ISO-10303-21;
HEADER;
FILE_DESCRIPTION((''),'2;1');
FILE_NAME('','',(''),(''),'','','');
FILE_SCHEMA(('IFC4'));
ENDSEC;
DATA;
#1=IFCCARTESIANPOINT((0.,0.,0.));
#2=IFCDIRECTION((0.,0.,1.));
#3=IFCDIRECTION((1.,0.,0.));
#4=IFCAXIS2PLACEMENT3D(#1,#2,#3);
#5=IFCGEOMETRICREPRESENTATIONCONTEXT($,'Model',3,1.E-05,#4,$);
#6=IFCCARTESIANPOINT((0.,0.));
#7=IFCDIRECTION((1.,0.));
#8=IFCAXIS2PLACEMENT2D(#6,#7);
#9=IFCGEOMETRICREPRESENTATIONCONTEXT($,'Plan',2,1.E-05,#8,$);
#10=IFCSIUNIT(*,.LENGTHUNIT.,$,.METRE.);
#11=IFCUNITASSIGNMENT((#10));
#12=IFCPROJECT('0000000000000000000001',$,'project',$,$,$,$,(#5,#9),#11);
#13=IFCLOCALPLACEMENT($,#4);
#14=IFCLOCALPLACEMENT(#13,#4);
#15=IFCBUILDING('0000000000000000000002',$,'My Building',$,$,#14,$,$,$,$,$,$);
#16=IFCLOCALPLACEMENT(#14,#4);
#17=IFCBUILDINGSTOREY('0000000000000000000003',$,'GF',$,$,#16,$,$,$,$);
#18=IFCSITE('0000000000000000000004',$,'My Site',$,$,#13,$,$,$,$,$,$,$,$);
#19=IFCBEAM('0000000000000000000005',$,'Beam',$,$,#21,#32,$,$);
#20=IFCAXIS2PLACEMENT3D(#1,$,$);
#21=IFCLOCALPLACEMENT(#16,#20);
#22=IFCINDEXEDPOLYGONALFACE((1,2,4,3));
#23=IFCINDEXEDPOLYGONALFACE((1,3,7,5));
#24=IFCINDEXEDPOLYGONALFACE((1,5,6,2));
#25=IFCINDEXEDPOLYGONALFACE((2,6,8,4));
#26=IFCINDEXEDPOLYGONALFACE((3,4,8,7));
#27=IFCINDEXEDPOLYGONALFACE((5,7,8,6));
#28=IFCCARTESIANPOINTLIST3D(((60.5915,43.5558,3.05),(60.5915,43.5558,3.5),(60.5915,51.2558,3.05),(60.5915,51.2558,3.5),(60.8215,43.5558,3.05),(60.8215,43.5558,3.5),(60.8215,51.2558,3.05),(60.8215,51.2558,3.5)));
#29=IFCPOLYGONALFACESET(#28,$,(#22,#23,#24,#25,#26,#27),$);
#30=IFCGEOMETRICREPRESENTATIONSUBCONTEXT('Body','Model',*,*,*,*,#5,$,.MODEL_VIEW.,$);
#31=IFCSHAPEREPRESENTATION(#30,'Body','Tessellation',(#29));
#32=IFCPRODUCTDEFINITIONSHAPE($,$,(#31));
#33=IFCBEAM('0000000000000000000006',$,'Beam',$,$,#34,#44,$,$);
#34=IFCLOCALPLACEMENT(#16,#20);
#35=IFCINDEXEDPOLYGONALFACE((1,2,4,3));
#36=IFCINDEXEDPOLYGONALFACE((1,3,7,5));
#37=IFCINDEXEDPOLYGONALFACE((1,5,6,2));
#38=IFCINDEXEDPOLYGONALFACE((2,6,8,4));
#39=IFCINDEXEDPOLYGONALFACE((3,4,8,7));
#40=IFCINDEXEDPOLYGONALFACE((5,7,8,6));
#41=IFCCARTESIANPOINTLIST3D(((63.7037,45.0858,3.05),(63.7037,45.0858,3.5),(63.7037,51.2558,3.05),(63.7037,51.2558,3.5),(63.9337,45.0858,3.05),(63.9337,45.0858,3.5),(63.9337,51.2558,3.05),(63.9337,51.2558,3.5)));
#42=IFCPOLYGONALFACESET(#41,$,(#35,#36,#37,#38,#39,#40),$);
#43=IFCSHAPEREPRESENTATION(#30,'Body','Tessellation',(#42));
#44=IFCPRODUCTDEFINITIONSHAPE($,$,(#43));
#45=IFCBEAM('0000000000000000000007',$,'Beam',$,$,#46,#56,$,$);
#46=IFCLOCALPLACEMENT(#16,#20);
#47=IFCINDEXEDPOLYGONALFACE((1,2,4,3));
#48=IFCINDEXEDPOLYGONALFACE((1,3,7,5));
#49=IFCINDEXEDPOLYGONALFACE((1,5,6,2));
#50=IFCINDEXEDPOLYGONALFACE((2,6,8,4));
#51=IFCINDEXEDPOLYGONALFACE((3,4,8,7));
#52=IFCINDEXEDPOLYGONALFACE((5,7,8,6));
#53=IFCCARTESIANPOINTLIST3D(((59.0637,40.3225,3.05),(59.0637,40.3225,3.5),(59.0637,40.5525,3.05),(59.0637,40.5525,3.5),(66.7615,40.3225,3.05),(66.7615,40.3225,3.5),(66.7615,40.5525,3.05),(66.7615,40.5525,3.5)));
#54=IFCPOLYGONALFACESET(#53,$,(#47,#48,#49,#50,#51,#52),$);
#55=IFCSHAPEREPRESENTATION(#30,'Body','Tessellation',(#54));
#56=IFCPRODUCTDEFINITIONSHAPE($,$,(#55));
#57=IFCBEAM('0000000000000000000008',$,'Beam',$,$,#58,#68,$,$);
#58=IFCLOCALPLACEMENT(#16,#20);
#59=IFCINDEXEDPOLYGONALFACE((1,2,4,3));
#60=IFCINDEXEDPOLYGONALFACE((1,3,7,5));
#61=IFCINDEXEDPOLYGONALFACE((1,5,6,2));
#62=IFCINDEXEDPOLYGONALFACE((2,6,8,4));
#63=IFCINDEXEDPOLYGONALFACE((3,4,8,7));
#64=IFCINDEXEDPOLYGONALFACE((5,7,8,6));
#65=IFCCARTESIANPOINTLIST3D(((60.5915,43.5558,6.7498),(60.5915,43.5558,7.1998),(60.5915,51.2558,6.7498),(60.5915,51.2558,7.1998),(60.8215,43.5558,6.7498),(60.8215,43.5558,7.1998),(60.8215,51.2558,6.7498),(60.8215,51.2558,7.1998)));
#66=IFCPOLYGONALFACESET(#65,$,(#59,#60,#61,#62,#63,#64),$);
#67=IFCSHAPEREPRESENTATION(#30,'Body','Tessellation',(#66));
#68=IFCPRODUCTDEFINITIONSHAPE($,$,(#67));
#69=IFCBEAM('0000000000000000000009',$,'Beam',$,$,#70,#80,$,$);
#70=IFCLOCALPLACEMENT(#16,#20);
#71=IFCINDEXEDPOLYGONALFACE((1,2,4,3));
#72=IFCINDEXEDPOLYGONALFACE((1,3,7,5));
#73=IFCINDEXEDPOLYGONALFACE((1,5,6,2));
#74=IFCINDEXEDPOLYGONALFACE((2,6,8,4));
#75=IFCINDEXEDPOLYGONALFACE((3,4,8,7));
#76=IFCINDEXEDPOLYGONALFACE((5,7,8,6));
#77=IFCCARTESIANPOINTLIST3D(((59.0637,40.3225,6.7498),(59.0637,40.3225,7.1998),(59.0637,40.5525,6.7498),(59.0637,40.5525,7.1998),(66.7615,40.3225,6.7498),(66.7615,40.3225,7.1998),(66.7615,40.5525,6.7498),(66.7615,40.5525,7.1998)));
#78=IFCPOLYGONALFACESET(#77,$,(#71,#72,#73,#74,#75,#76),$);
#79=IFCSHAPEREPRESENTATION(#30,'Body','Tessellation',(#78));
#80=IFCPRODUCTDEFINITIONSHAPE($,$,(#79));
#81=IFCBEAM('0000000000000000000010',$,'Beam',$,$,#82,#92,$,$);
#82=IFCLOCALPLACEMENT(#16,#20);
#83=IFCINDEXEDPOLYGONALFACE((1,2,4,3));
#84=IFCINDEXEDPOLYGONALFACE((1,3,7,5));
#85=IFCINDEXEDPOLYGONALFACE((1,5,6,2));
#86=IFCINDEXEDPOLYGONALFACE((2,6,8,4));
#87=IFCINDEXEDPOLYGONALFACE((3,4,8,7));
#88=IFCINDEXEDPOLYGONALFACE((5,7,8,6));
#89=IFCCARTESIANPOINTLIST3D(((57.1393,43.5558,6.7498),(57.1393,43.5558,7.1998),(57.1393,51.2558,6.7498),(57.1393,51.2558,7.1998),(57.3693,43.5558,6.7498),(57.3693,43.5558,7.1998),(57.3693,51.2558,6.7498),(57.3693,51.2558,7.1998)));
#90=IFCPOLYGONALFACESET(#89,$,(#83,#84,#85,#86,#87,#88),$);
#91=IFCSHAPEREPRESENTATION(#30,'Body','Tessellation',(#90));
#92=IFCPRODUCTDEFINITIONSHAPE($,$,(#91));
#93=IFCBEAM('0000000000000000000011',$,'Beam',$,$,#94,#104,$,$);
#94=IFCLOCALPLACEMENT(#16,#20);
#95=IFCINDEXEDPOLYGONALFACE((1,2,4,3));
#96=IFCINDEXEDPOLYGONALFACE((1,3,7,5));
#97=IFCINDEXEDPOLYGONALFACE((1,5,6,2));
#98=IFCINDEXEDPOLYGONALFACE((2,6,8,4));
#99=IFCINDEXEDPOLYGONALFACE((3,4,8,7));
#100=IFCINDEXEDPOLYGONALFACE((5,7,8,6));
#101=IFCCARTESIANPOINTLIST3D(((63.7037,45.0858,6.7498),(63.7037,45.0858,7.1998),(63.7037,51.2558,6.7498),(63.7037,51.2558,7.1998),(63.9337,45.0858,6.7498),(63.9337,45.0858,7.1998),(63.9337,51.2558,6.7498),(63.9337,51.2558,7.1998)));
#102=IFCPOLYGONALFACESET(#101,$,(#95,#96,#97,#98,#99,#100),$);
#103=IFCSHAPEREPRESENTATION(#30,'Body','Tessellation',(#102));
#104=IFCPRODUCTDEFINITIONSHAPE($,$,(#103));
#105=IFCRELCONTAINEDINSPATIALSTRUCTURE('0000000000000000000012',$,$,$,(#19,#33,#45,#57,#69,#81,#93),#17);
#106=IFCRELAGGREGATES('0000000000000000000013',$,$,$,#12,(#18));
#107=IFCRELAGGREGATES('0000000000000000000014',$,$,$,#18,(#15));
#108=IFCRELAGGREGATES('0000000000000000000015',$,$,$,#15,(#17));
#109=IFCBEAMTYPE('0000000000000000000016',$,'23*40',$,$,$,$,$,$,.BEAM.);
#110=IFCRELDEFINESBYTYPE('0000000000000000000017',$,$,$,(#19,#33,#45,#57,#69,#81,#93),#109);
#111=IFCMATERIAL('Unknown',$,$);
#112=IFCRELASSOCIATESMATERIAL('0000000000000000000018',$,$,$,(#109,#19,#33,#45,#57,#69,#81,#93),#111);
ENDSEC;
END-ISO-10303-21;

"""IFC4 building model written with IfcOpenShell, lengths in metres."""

from ifc_helpers import new_model, si_unit, frame, origin_with_axes, origin_2d_with_axis, place, context, subcontext, project, spatial, rectangle, extrude, material, material_profile, profile_set, profile_usage, type_object, element, save


model = new_model("IFC4")

# Units and contexts
model_context = context("Model", 3, precision=1e-05, world=origin_with_axes())
plan_context = context("Plan", 2, precision=1e-05, world=origin_2d_with_axis())
body_context = subcontext(model_context, "Body", "Model", "MODEL_VIEW")
ifc_project = project(units=[si_unit("LENGTHUNIT", "METRE")], contexts=[model_context, plan_context])

# Site, building, storey
site_placement = place(None, origin_with_axes())
site = spatial("IfcSite", under=ifc_project, at=site_placement, Name="My Site")
building_placement = place(site_placement, origin_with_axes())
building = spatial("IfcBuilding", under=site, at=building_placement, Name="My Building")
storey_placement = place(building_placement, origin_with_axes())
storey = spatial("IfcBuildingStorey", under=building, at=storey_placement, Name="GF")

# Shared definitions
ifc_material = material(Name="Unknown")

# Beams
ifc_material_profile_1 = material_profile(ifc_material, rectangle(XDim=0.23, YDim=0.45))
ifc_profile_set_1 = profile_set([ifc_material_profile_1])
beam_type = type_object("IfcBeamType", Name="23*40", PredefinedType="BEAM", material=ifc_profile_set_1)
ifc_profile_usage_1 = profile_usage(ifc_profile_set_1, cardinal=5)
beam_1_placement = place(storey_placement, frame((60.7065, 43.5558, 3.275), z_axis=(0.0, 1.0, 0.0), x_axis=(-1.0, 0.0, 0.0)))
element("IfcBeam", 1, at=beam_1_placement, inside=storey, type_object=beam_type, material=ifc_profile_usage_1, Name="Beam", context=body_context, shape_type="SweptSolid", body=[
    extrude(rectangle(XDim=0.23, YDim=0.45), origin_with_axes(), (0.0, 0.0, 1.0), 7.7),
])
ifc_profile_usage_2 = profile_usage(ifc_profile_set_1, cardinal=5)
beam_2_placement = place(storey_placement, frame((63.8187, 45.0858, 3.275), z_axis=(0.0, 1.0, 0.0), x_axis=(-1.0, 0.0, 0.0)))
element("IfcBeam", 2, at=beam_2_placement, inside=storey, type_object=beam_type, material=ifc_profile_usage_2, Name="Beam", context=body_context, shape_type="SweptSolid", body=[
    extrude(rectangle(XDim=0.23, YDim=0.45), origin_with_axes(), (0.0, 0.0, 1.0), 6.17),
])
ifc_profile_usage_3 = profile_usage(ifc_profile_set_1, cardinal=5)
beam_3_placement = place(storey_placement, frame((59.0637, 40.4375, 3.275), z_axis=(1.0, 0.0, 0.0), x_axis=(0.0, 1.0, 0.0)))
element("IfcBeam", 3, at=beam_3_placement, inside=storey, type_object=beam_type, material=ifc_profile_usage_3, Name="Beam", context=body_context, shape_type="SweptSolid", body=[
    extrude(rectangle(XDim=0.23, YDim=0.45), origin_with_axes(), (0.0, 0.0, 1.0), 7.6978),
])
ifc_profile_usage_4 = profile_usage(ifc_profile_set_1, cardinal=5)
beam_4_placement = place(storey_placement, frame((60.7065, 43.5558, 6.9748), z_axis=(0.0, 1.0, 0.0), x_axis=(-1.0, 0.0, 0.0)))
element("IfcBeam", 4, at=beam_4_placement, inside=storey, type_object=beam_type, material=ifc_profile_usage_4, Name="Beam", context=body_context, shape_type="SweptSolid", body=[
    extrude(rectangle(XDim=0.23, YDim=0.45), origin_with_axes(), (0.0, 0.0, 1.0), 7.7),
])
ifc_profile_usage_5 = profile_usage(ifc_profile_set_1, cardinal=5)
beam_5_placement = place(storey_placement, frame((59.0637, 40.4375, 6.9748), z_axis=(1.0, 0.0, 0.0), x_axis=(0.0, 1.0, 0.0)))
element("IfcBeam", 5, at=beam_5_placement, inside=storey, type_object=beam_type, material=ifc_profile_usage_5, Name="Beam", context=body_context, shape_type="SweptSolid", body=[
    extrude(rectangle(XDim=0.23, YDim=0.45), origin_with_axes(), (0.0, 0.0, 1.0), 7.6978),
])
ifc_profile_usage_6 = profile_usage(ifc_profile_set_1, cardinal=5)
beam_6_placement = place(storey_placement, frame((57.2543, 43.5558, 6.9748), z_axis=(0.0, 1.0, 0.0), x_axis=(-1.0, 0.0, 0.0)))
element("IfcBeam", 6, at=beam_6_placement, inside=storey, type_object=beam_type, material=ifc_profile_usage_6, Name="Beam", context=body_context, shape_type="SweptSolid", body=[
    extrude(rectangle(XDim=0.23, YDim=0.45), origin_with_axes(), (0.0, 0.0, 1.0), 7.7),
])
ifc_profile_usage_7 = profile_usage(ifc_profile_set_1, cardinal=5)
beam_7_placement = place(storey_placement, frame((63.8187, 45.0858, 6.9748), z_axis=(0.0, 1.0, 0.0), x_axis=(-1.0, 0.0, 0.0)))
element("IfcBeam", 7, at=beam_7_placement, inside=storey, type_object=beam_type, material=ifc_profile_usage_7, Name="Beam", context=body_context, shape_type="SweptSolid", body=[
    extrude(rectangle(XDim=0.23, YDim=0.45), origin_with_axes(), (0.0, 0.0, 1.0), 6.17),
])

save(model, "model.ifc")
